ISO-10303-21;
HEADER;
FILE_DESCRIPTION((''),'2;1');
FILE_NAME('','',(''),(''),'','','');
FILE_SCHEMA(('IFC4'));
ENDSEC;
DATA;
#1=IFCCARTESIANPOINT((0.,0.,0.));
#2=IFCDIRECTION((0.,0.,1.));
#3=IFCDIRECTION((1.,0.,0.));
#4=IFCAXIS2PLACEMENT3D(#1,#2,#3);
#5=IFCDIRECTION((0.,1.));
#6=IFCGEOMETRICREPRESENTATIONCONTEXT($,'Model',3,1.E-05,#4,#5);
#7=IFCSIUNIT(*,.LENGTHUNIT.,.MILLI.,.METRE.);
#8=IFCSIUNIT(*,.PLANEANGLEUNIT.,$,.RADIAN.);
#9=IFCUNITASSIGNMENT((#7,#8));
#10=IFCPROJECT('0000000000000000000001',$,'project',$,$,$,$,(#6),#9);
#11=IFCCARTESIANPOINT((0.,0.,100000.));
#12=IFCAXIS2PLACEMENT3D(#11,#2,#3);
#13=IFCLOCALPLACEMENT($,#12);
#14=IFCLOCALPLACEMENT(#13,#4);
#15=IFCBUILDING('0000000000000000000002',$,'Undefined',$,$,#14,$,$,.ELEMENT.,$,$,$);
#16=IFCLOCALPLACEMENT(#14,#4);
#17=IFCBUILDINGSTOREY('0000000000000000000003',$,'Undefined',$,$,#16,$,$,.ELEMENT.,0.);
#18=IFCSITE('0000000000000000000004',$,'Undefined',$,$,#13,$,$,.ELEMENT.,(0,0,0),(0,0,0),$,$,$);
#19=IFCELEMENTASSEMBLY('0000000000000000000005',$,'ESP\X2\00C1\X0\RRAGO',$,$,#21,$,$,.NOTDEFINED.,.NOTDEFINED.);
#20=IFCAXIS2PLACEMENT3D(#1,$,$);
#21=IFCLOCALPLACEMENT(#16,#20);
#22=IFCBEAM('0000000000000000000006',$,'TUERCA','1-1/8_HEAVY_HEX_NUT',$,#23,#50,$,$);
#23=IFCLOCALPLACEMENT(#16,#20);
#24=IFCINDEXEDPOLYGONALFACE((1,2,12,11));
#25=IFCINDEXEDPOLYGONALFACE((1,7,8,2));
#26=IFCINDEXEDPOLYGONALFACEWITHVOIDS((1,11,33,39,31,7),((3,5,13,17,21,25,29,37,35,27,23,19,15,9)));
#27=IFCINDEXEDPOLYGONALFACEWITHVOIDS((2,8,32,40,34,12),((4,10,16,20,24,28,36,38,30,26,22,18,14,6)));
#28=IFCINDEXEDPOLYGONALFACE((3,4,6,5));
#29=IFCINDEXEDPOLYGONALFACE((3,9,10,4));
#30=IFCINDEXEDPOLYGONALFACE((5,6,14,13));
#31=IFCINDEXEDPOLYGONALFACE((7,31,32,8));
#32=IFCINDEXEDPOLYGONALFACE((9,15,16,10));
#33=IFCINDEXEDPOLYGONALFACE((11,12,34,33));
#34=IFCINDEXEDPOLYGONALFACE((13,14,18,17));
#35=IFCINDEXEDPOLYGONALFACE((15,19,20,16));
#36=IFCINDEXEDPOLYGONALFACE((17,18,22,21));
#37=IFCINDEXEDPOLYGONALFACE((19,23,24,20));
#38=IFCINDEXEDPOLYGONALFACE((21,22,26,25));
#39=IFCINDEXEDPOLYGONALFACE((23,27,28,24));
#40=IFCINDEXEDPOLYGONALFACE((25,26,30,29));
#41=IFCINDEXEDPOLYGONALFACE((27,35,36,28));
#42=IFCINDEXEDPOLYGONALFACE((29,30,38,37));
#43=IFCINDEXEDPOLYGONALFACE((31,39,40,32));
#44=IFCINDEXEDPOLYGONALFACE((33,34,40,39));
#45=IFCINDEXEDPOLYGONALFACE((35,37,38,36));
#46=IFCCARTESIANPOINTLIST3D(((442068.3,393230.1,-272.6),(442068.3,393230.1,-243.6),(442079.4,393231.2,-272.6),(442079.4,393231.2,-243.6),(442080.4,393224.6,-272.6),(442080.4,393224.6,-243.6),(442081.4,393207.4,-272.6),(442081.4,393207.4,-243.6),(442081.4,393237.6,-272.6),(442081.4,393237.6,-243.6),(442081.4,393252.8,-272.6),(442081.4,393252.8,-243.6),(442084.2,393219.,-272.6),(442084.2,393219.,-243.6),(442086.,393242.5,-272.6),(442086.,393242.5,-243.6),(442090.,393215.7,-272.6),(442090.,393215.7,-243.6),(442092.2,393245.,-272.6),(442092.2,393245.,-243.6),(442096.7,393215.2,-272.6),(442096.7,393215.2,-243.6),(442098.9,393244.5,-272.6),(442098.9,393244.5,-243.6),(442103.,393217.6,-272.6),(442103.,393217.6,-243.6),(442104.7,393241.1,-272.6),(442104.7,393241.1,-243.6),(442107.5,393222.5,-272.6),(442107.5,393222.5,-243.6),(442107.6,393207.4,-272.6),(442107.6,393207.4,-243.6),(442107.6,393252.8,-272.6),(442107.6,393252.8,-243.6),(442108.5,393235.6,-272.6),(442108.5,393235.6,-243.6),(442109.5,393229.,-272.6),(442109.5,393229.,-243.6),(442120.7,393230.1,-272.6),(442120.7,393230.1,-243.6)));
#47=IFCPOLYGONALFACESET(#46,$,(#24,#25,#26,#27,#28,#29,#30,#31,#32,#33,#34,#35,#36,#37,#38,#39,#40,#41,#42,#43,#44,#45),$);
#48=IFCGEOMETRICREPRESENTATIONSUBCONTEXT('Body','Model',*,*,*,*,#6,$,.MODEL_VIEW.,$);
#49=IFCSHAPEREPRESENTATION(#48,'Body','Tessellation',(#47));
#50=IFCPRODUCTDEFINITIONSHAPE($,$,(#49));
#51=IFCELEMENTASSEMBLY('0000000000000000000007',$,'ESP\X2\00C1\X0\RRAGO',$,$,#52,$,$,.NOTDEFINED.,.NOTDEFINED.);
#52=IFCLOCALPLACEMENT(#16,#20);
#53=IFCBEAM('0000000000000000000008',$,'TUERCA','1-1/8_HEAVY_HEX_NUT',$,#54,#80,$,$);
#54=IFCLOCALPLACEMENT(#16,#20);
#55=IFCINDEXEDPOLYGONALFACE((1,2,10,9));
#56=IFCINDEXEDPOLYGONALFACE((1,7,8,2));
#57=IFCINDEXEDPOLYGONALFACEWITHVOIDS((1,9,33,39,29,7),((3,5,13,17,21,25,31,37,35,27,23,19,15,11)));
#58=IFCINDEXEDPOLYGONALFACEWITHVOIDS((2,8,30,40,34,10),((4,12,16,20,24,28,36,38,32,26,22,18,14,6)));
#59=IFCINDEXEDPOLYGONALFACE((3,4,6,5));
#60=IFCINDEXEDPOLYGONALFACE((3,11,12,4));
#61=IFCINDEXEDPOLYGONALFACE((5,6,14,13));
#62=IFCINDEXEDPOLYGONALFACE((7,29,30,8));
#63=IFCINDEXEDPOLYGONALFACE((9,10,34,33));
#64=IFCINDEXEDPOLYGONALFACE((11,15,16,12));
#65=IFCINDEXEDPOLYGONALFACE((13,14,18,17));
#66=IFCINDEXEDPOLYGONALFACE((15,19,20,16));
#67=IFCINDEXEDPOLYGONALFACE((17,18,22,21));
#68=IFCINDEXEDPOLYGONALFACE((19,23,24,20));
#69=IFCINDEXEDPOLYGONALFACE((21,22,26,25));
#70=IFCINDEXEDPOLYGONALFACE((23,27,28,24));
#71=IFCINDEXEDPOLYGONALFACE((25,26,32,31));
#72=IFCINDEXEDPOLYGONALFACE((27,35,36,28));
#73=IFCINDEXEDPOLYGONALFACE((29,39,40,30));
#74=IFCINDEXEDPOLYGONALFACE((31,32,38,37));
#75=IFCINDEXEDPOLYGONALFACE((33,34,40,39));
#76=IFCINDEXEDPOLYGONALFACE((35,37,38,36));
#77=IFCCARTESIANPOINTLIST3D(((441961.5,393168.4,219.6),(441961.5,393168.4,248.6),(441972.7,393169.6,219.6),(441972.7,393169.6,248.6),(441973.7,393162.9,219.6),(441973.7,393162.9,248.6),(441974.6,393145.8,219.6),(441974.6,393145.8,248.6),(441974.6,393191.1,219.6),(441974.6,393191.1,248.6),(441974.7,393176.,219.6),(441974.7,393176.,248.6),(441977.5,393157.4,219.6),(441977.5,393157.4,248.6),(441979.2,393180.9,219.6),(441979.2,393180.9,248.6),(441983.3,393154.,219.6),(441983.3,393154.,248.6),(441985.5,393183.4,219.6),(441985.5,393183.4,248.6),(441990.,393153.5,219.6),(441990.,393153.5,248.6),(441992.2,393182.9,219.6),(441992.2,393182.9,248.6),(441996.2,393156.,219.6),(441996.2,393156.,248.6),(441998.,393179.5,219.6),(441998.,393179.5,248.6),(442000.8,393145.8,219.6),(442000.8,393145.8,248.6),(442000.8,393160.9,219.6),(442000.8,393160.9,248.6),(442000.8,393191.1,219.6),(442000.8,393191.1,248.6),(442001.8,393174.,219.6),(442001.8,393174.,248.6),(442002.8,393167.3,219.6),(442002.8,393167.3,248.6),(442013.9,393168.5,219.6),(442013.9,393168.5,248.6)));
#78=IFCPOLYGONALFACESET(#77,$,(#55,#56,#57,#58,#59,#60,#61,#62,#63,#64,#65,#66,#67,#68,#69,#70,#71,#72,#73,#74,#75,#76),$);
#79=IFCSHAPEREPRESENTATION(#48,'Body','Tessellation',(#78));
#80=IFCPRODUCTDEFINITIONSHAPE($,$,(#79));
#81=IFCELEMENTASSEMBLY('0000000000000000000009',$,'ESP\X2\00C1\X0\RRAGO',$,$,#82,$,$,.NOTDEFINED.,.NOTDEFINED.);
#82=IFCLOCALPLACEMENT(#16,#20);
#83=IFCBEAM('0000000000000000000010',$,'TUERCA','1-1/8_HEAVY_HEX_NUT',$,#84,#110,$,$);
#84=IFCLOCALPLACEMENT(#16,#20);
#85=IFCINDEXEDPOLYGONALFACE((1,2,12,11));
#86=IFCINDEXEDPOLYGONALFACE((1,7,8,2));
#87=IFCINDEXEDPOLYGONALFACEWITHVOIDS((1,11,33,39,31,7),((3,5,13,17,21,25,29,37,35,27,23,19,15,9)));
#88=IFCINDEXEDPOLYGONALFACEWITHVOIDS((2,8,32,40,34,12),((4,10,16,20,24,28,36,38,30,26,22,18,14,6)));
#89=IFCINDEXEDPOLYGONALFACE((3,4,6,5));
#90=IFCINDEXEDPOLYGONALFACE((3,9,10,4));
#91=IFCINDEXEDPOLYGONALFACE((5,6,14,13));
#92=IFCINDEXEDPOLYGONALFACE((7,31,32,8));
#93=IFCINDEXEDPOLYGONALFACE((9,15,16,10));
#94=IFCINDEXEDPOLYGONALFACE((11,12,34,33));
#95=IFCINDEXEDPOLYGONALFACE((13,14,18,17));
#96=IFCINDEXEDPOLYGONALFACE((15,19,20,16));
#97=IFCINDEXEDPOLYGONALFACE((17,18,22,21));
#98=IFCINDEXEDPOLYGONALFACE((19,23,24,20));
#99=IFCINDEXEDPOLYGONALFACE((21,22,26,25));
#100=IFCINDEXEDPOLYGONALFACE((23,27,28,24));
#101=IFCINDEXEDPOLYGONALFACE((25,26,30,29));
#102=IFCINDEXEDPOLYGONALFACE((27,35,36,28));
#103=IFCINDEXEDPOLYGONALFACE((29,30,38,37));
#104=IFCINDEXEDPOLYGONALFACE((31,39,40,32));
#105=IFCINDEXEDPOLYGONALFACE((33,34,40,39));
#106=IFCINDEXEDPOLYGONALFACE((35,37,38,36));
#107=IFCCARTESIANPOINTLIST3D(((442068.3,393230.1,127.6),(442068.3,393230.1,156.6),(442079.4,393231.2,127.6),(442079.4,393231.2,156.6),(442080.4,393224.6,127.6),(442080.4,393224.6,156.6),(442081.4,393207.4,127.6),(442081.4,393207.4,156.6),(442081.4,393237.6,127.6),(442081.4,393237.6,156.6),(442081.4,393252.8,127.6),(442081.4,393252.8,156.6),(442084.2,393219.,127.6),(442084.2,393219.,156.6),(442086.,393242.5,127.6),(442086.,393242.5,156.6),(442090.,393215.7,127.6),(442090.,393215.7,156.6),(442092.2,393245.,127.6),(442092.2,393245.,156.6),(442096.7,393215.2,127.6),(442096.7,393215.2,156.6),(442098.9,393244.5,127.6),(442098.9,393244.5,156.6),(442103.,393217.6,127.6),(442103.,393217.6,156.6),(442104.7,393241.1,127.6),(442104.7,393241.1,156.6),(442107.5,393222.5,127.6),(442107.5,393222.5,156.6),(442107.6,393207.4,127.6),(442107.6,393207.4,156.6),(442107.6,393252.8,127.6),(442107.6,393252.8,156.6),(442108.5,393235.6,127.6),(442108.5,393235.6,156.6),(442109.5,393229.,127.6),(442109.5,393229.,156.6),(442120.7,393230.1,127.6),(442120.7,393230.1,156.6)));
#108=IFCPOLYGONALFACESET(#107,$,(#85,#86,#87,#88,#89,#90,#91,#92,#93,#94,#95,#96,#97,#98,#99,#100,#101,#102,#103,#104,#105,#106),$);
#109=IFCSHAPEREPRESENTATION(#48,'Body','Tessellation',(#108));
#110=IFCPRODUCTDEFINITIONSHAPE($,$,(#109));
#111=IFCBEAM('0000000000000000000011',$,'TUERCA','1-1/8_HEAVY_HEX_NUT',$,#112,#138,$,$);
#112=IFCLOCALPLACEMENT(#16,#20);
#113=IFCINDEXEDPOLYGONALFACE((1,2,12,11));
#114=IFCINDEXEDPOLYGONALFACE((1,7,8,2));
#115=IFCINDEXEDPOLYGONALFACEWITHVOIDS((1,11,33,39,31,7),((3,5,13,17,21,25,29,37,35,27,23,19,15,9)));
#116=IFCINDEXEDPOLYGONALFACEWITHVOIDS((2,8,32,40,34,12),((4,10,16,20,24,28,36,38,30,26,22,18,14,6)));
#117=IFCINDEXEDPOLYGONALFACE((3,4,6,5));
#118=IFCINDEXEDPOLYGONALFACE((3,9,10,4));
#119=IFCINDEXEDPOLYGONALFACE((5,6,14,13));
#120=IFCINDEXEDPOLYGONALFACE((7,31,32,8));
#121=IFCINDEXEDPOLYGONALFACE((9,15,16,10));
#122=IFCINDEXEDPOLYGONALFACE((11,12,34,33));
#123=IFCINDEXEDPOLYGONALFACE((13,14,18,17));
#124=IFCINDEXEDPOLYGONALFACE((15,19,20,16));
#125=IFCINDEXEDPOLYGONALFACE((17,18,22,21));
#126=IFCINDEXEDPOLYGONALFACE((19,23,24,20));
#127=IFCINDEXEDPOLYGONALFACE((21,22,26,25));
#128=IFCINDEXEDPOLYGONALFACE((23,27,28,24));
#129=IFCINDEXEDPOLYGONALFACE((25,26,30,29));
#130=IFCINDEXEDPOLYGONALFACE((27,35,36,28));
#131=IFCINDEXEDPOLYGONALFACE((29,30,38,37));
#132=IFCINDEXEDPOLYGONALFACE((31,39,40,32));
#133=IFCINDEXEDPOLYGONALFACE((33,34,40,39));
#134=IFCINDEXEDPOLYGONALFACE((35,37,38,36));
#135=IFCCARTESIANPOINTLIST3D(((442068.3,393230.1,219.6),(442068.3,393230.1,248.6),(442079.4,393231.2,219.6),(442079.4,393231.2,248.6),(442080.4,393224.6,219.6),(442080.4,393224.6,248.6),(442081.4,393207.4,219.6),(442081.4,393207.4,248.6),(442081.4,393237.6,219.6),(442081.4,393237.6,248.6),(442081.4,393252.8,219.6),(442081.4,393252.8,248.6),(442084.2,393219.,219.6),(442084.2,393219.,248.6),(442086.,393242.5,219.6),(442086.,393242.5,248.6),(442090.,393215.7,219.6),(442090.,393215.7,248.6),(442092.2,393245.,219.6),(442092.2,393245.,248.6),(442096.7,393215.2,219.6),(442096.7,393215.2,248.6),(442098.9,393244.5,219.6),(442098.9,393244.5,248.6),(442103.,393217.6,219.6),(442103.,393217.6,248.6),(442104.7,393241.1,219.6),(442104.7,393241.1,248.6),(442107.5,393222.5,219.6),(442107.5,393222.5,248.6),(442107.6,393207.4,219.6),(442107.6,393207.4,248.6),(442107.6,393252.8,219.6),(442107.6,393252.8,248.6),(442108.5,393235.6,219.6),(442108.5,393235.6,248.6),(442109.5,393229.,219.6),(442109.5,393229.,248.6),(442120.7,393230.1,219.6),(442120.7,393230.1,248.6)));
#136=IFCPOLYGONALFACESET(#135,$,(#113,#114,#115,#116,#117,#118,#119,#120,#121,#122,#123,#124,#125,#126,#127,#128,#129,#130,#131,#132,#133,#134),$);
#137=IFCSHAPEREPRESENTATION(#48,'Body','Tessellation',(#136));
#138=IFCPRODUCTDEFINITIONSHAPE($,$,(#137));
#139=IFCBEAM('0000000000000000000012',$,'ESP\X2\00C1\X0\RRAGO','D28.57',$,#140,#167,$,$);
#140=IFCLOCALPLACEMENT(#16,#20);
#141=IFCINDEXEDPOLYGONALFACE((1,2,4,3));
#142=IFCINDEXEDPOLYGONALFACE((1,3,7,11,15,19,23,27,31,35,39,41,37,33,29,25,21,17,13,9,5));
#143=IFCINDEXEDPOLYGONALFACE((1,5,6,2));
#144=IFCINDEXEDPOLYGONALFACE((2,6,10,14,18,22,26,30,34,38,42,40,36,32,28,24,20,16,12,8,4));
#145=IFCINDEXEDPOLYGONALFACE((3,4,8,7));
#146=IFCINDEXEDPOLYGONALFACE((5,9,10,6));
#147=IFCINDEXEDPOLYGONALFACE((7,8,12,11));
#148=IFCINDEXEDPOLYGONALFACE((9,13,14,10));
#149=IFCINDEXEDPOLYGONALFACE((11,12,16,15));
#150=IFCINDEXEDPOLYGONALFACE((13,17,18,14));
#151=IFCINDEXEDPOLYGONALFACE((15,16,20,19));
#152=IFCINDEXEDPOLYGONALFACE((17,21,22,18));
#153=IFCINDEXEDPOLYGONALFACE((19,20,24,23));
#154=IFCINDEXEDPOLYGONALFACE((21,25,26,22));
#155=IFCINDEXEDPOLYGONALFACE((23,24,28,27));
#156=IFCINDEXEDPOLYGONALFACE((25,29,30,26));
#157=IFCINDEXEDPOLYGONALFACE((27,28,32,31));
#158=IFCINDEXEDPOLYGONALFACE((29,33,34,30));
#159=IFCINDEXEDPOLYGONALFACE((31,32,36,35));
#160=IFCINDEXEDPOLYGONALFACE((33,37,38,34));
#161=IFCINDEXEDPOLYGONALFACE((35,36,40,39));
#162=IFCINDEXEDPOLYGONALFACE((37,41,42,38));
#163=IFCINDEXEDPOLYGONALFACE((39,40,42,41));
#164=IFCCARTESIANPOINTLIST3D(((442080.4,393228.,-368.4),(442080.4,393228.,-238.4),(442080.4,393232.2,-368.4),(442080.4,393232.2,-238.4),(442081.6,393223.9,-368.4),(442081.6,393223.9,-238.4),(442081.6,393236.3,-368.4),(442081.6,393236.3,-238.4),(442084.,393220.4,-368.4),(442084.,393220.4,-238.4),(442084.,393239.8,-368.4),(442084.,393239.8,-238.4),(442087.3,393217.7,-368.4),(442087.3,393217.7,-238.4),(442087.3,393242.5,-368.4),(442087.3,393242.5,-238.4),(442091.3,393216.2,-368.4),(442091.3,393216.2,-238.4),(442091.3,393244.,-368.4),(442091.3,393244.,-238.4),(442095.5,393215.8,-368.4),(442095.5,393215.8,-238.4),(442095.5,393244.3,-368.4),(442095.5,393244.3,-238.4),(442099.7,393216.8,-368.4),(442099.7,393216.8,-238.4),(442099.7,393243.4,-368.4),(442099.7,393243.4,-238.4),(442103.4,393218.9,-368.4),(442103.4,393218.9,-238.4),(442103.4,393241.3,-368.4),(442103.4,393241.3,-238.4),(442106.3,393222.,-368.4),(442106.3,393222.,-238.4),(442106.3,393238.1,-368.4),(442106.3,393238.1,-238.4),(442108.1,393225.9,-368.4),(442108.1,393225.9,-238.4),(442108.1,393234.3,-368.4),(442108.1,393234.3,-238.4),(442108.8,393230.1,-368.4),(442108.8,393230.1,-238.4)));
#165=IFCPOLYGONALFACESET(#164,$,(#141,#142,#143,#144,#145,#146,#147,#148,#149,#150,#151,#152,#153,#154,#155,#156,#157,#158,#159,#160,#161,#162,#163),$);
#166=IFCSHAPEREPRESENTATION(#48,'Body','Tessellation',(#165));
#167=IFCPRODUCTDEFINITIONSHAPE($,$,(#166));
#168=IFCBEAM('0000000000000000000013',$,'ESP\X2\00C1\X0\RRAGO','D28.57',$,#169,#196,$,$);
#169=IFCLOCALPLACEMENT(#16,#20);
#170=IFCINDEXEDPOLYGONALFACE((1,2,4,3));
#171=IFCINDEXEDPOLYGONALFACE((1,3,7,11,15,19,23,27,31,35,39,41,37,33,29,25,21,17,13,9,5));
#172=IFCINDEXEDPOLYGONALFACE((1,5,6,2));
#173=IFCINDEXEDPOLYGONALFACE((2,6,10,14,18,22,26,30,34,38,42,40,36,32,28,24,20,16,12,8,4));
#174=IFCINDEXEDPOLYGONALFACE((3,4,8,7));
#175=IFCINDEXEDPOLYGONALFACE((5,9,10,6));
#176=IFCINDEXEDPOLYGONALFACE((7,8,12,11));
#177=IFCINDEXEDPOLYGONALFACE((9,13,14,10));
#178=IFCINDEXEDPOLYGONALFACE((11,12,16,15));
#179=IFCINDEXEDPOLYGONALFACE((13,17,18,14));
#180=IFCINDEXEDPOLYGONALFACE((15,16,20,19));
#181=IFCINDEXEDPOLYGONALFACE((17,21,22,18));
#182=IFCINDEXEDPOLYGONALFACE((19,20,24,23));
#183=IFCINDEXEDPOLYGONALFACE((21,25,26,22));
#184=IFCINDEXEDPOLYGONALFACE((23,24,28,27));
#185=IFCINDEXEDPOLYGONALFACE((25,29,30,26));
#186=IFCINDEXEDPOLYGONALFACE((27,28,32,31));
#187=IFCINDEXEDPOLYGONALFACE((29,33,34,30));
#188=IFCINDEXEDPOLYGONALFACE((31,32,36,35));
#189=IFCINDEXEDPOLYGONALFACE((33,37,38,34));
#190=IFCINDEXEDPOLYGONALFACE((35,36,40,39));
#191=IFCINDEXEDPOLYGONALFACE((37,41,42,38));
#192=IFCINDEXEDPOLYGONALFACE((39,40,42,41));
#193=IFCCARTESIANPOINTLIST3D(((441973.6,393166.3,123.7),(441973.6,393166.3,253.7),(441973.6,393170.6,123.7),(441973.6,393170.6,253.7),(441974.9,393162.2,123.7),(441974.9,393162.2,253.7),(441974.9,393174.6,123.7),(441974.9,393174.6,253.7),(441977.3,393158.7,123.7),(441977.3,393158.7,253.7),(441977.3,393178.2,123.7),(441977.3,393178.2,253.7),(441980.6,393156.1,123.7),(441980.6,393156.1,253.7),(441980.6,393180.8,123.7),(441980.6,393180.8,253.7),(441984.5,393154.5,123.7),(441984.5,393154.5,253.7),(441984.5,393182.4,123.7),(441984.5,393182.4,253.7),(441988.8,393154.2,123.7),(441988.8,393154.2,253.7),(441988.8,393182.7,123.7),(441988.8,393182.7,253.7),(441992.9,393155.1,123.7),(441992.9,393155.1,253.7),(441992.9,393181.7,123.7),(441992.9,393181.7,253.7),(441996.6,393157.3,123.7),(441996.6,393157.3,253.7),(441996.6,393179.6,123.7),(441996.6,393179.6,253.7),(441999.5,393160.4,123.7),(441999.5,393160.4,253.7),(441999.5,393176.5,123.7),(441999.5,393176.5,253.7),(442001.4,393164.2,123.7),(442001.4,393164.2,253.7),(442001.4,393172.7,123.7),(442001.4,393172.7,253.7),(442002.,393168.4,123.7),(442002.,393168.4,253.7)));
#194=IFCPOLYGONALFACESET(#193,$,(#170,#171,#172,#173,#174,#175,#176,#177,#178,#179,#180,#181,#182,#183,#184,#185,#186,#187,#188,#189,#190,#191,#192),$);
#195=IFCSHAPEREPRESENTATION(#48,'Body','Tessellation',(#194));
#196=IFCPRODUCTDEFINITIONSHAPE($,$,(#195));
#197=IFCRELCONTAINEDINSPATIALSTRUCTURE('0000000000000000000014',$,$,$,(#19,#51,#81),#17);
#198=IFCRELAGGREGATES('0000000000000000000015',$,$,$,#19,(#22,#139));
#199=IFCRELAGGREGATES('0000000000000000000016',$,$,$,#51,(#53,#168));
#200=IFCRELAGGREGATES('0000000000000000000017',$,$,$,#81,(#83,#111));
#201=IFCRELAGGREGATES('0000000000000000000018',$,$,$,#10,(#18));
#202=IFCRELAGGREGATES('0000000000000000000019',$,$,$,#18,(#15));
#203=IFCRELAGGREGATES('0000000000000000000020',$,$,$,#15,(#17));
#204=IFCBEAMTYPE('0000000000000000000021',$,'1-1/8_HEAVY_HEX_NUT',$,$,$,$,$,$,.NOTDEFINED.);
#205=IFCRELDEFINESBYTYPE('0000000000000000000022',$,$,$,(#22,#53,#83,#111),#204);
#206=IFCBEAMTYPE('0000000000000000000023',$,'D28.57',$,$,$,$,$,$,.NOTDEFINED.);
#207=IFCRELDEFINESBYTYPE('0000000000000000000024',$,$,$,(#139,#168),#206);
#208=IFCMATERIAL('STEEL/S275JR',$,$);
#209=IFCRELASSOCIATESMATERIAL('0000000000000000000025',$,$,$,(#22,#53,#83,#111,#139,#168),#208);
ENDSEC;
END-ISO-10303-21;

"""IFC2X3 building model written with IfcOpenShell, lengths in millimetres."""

from ifc_helpers import new_model, si_unit, direction, frame, origin_with_axes, origin_2d_with_axis, place, context, subcontext, project, spatial, polyline, circle, outline, extrude, material, type_object, element, aggregate, save


model = new_model("IFC2X3")

# Units and contexts
model_context = context("Model", 3, precision=1e-05, world=origin_with_axes(), true_north=direction((0.0, 1.0)))
body_context = subcontext(model_context, "Body", "Model", "MODEL_VIEW")
ifc_project = project(units=[si_unit("LENGTHUNIT", "METRE", prefix="MILLI"), si_unit("PLANEANGLEUNIT", "RADIAN")], contexts=[model_context])

# Site, building, storey
site_placement = place(None, frame((0.0, 0.0, 100000.0), z_axis=(0.0, 0.0, 1.0), x_axis=(1.0, 0.0, 0.0)))
site = spatial("IfcSite", under=ifc_project, at=site_placement, Name="Undefined", CompositionType="ELEMENT", RefLatitude=(0, 0, 0), RefLongitude=(0, 0, 0))
building_placement = place(site_placement, origin_with_axes())
building = spatial("IfcBuilding", under=site, at=building_placement, Name="Undefined", CompositionType="ELEMENT")
storey_placement = place(building_placement, origin_with_axes())
storey = spatial("IfcBuildingStorey", under=building, at=storey_placement, Name="Undefined", CompositionType="ELEMENT", Elevation=0.0)

# Shared definitions
ifc_material_1 = material(Name="STEEL/S275JR")

# Element assembly, beam
assembly_1_placement = place(storey_placement, origin_with_axes())
assembly_1 = element("IfcElementAssembly", 1, at=assembly_1_placement, inside=storey, Name="ESPÁRRAGO", AssemblyPlace="NOTDEFINED", PredefinedType="NOTDEFINED")
beam_type_1 = type_object("IfcBeamType", Name="1-1/8_HEAVY_HEX_NUT", PredefinedType="NOTDEFINED")
beam_1_placement = place(assembly_1_placement, frame((442094.5, 393230.1, -243.6), z_axis=(0.866025, -0.5, 0.0), x_axis=(0.0, 0.0, -1.0)))
beam_1 = element("IfcBeam", 2, at=beam_1_placement, type_object=beam_type_1, material=ifc_material_1, Name="TUERCA", Description="1-1/8_HEAVY_HEX_NUT", context=body_context, shape_type="SweptSolid", body=[
    extrude(outline(polyline([(-13.1, -22.7), (-26.2, 0.0), (-13.1, 22.7), (13.1, 22.7), (26.2, 0.0), (13.1, -22.7), (-13.1, -22.7)]), holes=[polyline([(6.5, 13.6), (0.0, 15.1), (-6.5, 13.6), (-11.8, 9.4), (-14.7, 3.4), (-14.7, -3.4), (-11.8, -9.4), (-6.5, -13.6), (0.0, -15.1), (6.5, -13.6), (11.8, -9.4), (14.7, -3.4), (14.7, 3.4), (11.8, 9.4), (6.5, 13.6)])]), frame((29.0, 0.0, 0.0), z_axis=(-1.0, 0.0, 0.0), x_axis=(0.0, -1.0, 0.0)), (0.0, 0.0, 1.0), 29.0),
])

# Element assembly, beam
assembly_2_placement = place(storey_placement, origin_with_axes())
assembly_2 = element("IfcElementAssembly", 3, at=assembly_2_placement, inside=storey, Name="ESPÁRRAGO", AssemblyPlace="NOTDEFINED", PredefinedType="NOTDEFINED")
beam_2_placement = place(assembly_2_placement, frame((441987.7, 393168.4, 248.6), z_axis=(0.866025, -0.5, 0.0), x_axis=(0.0, 0.0, -1.0)))
beam_2 = element("IfcBeam", 4, at=beam_2_placement, type_object=beam_type_1, material=ifc_material_1, Name="TUERCA", Description="1-1/8_HEAVY_HEX_NUT", context=body_context, shape_type="SweptSolid", body=[
    extrude(outline(polyline([(-13.1, -22.7), (-26.2, 0.0), (-13.1, 22.7), (13.1, 22.7), (26.2, 0.0), (13.1, -22.7), (-13.1, -22.7)]), holes=[polyline([(6.5, 13.6), (0.0, 15.1), (-6.5, 13.6), (-11.8, 9.4), (-14.7, 3.4), (-14.7, -3.4), (-11.8, -9.4), (-6.5, -13.6), (0.0, -15.1), (6.5, -13.6), (11.8, -9.4), (14.7, -3.4), (14.7, 3.4), (11.8, 9.4), (6.5, 13.6)])]), frame((29.0, 0.0, 0.0), z_axis=(-1.0, 0.0, 0.0), x_axis=(0.0, -1.0, 0.0)), (0.0, 0.0, 1.0), 29.0),
])

# Element assembly, beams
assembly_3_placement = place(storey_placement, origin_with_axes())
assembly_3 = element("IfcElementAssembly", 5, at=assembly_3_placement, inside=storey, Name="ESPÁRRAGO", AssemblyPlace="NOTDEFINED", PredefinedType="NOTDEFINED")
beam_3_placement = place(assembly_3_placement, frame((442094.5, 393230.1, 156.6), z_axis=(0.866025, -0.5, 0.0), x_axis=(0.0, 0.0, -1.0)))
beam_3 = element("IfcBeam", 6, at=beam_3_placement, type_object=beam_type_1, material=ifc_material_1, Name="TUERCA", Description="1-1/8_HEAVY_HEX_NUT", context=body_context, shape_type="SweptSolid", body=[
    extrude(outline(polyline([(-13.1, -22.7), (-26.2, 0.0), (-13.1, 22.7), (13.1, 22.7), (26.2, 0.0), (13.1, -22.7), (-13.1, -22.7)]), holes=[polyline([(6.5, 13.6), (0.0, 15.1), (-6.5, 13.6), (-11.8, 9.4), (-14.7, 3.4), (-14.7, -3.4), (-11.8, -9.4), (-6.5, -13.6), (0.0, -15.1), (6.5, -13.6), (11.8, -9.4), (14.7, -3.4), (14.7, 3.4), (11.8, 9.4), (6.5, 13.6)])]), frame((29.0, 0.0, 0.0), z_axis=(-1.0, 0.0, 0.0), x_axis=(0.0, -1.0, 0.0)), (0.0, 0.0, 1.0), 29.0),
])
beam_4_placement = place(assembly_3_placement, frame((442094.5, 393230.1, 248.6), z_axis=(0.866025, -0.5, 0.0), x_axis=(0.0, 0.0, -1.0)))
beam_4 = element("IfcBeam", 7, at=beam_4_placement, type_object=beam_type_1, material=ifc_material_1, Name="TUERCA", Description="1-1/8_HEAVY_HEX_NUT", context=body_context, shape_type="SweptSolid", body=[
    extrude(outline(polyline([(-13.1, -22.7), (-26.2, 0.0), (-13.1, 22.7), (13.1, 22.7), (26.2, 0.0), (13.1, -22.7), (-13.1, -22.7)]), holes=[polyline([(6.5, 13.6), (0.0, 15.1), (-6.5, 13.6), (-11.8, 9.4), (-14.7, 3.4), (-14.7, -3.4), (-11.8, -9.4), (-6.5, -13.6), (0.0, -15.1), (6.5, -13.6), (11.8, -9.4), (14.7, -3.4), (14.7, 3.4), (11.8, 9.4), (6.5, 13.6)])]), frame((29.0, 0.0, 0.0), z_axis=(-1.0, 0.0, 0.0), x_axis=(0.0, -1.0, 0.0)), (0.0, 0.0, 1.0), 29.0),
])

# Beams
beam_type_2 = type_object("IfcBeamType", Name="D28.57", PredefinedType="NOTDEFINED")
beam_5_placement = place(assembly_1_placement, frame((442094.5, 393230.1, -238.4), z_axis=(0.866025, -0.5, 0.0), x_axis=(0.0, 0.0, -1.0)))
beam_5 = element("IfcBeam", 8, at=beam_5_placement, type_object=beam_type_2, material=ifc_material_1, Name="ESPÁRRAGO", Description="D28.57", context=body_context, shape_type="SweptSolid", body=[
    extrude(circle(Radius=14.3, at=origin_2d_with_axis()), frame((130.0, 0.0, 0.0), z_axis=(-1.0, 0.0, 0.0), x_axis=(0.0, -1.0, 0.0)), (0.0, 0.0, 1.0), 130.0),
])
aggregate(assembly_1, [beam_1, beam_5])
beam_6_placement = place(assembly_2_placement, frame((441987.7, 393168.4, 253.7), z_axis=(0.866025, -0.5, 0.0), x_axis=(0.0, 0.0, -1.0)))
beam_6 = element("IfcBeam", 9, at=beam_6_placement, type_object=beam_type_2, material=ifc_material_1, Name="ESPÁRRAGO", Description="D28.57", context=body_context, shape_type="SweptSolid", body=[
    extrude(circle(Radius=14.3, at=origin_2d_with_axis()), frame((130.0, 0.0, 0.0), z_axis=(-1.0, 0.0, 0.0), x_axis=(0.0, -1.0, 0.0)), (0.0, 0.0, 1.0), 130.0),
])
aggregate(assembly_2, [beam_2, beam_6])
aggregate(assembly_3, [beam_3, beam_4])

save(model, "model.ifc")
